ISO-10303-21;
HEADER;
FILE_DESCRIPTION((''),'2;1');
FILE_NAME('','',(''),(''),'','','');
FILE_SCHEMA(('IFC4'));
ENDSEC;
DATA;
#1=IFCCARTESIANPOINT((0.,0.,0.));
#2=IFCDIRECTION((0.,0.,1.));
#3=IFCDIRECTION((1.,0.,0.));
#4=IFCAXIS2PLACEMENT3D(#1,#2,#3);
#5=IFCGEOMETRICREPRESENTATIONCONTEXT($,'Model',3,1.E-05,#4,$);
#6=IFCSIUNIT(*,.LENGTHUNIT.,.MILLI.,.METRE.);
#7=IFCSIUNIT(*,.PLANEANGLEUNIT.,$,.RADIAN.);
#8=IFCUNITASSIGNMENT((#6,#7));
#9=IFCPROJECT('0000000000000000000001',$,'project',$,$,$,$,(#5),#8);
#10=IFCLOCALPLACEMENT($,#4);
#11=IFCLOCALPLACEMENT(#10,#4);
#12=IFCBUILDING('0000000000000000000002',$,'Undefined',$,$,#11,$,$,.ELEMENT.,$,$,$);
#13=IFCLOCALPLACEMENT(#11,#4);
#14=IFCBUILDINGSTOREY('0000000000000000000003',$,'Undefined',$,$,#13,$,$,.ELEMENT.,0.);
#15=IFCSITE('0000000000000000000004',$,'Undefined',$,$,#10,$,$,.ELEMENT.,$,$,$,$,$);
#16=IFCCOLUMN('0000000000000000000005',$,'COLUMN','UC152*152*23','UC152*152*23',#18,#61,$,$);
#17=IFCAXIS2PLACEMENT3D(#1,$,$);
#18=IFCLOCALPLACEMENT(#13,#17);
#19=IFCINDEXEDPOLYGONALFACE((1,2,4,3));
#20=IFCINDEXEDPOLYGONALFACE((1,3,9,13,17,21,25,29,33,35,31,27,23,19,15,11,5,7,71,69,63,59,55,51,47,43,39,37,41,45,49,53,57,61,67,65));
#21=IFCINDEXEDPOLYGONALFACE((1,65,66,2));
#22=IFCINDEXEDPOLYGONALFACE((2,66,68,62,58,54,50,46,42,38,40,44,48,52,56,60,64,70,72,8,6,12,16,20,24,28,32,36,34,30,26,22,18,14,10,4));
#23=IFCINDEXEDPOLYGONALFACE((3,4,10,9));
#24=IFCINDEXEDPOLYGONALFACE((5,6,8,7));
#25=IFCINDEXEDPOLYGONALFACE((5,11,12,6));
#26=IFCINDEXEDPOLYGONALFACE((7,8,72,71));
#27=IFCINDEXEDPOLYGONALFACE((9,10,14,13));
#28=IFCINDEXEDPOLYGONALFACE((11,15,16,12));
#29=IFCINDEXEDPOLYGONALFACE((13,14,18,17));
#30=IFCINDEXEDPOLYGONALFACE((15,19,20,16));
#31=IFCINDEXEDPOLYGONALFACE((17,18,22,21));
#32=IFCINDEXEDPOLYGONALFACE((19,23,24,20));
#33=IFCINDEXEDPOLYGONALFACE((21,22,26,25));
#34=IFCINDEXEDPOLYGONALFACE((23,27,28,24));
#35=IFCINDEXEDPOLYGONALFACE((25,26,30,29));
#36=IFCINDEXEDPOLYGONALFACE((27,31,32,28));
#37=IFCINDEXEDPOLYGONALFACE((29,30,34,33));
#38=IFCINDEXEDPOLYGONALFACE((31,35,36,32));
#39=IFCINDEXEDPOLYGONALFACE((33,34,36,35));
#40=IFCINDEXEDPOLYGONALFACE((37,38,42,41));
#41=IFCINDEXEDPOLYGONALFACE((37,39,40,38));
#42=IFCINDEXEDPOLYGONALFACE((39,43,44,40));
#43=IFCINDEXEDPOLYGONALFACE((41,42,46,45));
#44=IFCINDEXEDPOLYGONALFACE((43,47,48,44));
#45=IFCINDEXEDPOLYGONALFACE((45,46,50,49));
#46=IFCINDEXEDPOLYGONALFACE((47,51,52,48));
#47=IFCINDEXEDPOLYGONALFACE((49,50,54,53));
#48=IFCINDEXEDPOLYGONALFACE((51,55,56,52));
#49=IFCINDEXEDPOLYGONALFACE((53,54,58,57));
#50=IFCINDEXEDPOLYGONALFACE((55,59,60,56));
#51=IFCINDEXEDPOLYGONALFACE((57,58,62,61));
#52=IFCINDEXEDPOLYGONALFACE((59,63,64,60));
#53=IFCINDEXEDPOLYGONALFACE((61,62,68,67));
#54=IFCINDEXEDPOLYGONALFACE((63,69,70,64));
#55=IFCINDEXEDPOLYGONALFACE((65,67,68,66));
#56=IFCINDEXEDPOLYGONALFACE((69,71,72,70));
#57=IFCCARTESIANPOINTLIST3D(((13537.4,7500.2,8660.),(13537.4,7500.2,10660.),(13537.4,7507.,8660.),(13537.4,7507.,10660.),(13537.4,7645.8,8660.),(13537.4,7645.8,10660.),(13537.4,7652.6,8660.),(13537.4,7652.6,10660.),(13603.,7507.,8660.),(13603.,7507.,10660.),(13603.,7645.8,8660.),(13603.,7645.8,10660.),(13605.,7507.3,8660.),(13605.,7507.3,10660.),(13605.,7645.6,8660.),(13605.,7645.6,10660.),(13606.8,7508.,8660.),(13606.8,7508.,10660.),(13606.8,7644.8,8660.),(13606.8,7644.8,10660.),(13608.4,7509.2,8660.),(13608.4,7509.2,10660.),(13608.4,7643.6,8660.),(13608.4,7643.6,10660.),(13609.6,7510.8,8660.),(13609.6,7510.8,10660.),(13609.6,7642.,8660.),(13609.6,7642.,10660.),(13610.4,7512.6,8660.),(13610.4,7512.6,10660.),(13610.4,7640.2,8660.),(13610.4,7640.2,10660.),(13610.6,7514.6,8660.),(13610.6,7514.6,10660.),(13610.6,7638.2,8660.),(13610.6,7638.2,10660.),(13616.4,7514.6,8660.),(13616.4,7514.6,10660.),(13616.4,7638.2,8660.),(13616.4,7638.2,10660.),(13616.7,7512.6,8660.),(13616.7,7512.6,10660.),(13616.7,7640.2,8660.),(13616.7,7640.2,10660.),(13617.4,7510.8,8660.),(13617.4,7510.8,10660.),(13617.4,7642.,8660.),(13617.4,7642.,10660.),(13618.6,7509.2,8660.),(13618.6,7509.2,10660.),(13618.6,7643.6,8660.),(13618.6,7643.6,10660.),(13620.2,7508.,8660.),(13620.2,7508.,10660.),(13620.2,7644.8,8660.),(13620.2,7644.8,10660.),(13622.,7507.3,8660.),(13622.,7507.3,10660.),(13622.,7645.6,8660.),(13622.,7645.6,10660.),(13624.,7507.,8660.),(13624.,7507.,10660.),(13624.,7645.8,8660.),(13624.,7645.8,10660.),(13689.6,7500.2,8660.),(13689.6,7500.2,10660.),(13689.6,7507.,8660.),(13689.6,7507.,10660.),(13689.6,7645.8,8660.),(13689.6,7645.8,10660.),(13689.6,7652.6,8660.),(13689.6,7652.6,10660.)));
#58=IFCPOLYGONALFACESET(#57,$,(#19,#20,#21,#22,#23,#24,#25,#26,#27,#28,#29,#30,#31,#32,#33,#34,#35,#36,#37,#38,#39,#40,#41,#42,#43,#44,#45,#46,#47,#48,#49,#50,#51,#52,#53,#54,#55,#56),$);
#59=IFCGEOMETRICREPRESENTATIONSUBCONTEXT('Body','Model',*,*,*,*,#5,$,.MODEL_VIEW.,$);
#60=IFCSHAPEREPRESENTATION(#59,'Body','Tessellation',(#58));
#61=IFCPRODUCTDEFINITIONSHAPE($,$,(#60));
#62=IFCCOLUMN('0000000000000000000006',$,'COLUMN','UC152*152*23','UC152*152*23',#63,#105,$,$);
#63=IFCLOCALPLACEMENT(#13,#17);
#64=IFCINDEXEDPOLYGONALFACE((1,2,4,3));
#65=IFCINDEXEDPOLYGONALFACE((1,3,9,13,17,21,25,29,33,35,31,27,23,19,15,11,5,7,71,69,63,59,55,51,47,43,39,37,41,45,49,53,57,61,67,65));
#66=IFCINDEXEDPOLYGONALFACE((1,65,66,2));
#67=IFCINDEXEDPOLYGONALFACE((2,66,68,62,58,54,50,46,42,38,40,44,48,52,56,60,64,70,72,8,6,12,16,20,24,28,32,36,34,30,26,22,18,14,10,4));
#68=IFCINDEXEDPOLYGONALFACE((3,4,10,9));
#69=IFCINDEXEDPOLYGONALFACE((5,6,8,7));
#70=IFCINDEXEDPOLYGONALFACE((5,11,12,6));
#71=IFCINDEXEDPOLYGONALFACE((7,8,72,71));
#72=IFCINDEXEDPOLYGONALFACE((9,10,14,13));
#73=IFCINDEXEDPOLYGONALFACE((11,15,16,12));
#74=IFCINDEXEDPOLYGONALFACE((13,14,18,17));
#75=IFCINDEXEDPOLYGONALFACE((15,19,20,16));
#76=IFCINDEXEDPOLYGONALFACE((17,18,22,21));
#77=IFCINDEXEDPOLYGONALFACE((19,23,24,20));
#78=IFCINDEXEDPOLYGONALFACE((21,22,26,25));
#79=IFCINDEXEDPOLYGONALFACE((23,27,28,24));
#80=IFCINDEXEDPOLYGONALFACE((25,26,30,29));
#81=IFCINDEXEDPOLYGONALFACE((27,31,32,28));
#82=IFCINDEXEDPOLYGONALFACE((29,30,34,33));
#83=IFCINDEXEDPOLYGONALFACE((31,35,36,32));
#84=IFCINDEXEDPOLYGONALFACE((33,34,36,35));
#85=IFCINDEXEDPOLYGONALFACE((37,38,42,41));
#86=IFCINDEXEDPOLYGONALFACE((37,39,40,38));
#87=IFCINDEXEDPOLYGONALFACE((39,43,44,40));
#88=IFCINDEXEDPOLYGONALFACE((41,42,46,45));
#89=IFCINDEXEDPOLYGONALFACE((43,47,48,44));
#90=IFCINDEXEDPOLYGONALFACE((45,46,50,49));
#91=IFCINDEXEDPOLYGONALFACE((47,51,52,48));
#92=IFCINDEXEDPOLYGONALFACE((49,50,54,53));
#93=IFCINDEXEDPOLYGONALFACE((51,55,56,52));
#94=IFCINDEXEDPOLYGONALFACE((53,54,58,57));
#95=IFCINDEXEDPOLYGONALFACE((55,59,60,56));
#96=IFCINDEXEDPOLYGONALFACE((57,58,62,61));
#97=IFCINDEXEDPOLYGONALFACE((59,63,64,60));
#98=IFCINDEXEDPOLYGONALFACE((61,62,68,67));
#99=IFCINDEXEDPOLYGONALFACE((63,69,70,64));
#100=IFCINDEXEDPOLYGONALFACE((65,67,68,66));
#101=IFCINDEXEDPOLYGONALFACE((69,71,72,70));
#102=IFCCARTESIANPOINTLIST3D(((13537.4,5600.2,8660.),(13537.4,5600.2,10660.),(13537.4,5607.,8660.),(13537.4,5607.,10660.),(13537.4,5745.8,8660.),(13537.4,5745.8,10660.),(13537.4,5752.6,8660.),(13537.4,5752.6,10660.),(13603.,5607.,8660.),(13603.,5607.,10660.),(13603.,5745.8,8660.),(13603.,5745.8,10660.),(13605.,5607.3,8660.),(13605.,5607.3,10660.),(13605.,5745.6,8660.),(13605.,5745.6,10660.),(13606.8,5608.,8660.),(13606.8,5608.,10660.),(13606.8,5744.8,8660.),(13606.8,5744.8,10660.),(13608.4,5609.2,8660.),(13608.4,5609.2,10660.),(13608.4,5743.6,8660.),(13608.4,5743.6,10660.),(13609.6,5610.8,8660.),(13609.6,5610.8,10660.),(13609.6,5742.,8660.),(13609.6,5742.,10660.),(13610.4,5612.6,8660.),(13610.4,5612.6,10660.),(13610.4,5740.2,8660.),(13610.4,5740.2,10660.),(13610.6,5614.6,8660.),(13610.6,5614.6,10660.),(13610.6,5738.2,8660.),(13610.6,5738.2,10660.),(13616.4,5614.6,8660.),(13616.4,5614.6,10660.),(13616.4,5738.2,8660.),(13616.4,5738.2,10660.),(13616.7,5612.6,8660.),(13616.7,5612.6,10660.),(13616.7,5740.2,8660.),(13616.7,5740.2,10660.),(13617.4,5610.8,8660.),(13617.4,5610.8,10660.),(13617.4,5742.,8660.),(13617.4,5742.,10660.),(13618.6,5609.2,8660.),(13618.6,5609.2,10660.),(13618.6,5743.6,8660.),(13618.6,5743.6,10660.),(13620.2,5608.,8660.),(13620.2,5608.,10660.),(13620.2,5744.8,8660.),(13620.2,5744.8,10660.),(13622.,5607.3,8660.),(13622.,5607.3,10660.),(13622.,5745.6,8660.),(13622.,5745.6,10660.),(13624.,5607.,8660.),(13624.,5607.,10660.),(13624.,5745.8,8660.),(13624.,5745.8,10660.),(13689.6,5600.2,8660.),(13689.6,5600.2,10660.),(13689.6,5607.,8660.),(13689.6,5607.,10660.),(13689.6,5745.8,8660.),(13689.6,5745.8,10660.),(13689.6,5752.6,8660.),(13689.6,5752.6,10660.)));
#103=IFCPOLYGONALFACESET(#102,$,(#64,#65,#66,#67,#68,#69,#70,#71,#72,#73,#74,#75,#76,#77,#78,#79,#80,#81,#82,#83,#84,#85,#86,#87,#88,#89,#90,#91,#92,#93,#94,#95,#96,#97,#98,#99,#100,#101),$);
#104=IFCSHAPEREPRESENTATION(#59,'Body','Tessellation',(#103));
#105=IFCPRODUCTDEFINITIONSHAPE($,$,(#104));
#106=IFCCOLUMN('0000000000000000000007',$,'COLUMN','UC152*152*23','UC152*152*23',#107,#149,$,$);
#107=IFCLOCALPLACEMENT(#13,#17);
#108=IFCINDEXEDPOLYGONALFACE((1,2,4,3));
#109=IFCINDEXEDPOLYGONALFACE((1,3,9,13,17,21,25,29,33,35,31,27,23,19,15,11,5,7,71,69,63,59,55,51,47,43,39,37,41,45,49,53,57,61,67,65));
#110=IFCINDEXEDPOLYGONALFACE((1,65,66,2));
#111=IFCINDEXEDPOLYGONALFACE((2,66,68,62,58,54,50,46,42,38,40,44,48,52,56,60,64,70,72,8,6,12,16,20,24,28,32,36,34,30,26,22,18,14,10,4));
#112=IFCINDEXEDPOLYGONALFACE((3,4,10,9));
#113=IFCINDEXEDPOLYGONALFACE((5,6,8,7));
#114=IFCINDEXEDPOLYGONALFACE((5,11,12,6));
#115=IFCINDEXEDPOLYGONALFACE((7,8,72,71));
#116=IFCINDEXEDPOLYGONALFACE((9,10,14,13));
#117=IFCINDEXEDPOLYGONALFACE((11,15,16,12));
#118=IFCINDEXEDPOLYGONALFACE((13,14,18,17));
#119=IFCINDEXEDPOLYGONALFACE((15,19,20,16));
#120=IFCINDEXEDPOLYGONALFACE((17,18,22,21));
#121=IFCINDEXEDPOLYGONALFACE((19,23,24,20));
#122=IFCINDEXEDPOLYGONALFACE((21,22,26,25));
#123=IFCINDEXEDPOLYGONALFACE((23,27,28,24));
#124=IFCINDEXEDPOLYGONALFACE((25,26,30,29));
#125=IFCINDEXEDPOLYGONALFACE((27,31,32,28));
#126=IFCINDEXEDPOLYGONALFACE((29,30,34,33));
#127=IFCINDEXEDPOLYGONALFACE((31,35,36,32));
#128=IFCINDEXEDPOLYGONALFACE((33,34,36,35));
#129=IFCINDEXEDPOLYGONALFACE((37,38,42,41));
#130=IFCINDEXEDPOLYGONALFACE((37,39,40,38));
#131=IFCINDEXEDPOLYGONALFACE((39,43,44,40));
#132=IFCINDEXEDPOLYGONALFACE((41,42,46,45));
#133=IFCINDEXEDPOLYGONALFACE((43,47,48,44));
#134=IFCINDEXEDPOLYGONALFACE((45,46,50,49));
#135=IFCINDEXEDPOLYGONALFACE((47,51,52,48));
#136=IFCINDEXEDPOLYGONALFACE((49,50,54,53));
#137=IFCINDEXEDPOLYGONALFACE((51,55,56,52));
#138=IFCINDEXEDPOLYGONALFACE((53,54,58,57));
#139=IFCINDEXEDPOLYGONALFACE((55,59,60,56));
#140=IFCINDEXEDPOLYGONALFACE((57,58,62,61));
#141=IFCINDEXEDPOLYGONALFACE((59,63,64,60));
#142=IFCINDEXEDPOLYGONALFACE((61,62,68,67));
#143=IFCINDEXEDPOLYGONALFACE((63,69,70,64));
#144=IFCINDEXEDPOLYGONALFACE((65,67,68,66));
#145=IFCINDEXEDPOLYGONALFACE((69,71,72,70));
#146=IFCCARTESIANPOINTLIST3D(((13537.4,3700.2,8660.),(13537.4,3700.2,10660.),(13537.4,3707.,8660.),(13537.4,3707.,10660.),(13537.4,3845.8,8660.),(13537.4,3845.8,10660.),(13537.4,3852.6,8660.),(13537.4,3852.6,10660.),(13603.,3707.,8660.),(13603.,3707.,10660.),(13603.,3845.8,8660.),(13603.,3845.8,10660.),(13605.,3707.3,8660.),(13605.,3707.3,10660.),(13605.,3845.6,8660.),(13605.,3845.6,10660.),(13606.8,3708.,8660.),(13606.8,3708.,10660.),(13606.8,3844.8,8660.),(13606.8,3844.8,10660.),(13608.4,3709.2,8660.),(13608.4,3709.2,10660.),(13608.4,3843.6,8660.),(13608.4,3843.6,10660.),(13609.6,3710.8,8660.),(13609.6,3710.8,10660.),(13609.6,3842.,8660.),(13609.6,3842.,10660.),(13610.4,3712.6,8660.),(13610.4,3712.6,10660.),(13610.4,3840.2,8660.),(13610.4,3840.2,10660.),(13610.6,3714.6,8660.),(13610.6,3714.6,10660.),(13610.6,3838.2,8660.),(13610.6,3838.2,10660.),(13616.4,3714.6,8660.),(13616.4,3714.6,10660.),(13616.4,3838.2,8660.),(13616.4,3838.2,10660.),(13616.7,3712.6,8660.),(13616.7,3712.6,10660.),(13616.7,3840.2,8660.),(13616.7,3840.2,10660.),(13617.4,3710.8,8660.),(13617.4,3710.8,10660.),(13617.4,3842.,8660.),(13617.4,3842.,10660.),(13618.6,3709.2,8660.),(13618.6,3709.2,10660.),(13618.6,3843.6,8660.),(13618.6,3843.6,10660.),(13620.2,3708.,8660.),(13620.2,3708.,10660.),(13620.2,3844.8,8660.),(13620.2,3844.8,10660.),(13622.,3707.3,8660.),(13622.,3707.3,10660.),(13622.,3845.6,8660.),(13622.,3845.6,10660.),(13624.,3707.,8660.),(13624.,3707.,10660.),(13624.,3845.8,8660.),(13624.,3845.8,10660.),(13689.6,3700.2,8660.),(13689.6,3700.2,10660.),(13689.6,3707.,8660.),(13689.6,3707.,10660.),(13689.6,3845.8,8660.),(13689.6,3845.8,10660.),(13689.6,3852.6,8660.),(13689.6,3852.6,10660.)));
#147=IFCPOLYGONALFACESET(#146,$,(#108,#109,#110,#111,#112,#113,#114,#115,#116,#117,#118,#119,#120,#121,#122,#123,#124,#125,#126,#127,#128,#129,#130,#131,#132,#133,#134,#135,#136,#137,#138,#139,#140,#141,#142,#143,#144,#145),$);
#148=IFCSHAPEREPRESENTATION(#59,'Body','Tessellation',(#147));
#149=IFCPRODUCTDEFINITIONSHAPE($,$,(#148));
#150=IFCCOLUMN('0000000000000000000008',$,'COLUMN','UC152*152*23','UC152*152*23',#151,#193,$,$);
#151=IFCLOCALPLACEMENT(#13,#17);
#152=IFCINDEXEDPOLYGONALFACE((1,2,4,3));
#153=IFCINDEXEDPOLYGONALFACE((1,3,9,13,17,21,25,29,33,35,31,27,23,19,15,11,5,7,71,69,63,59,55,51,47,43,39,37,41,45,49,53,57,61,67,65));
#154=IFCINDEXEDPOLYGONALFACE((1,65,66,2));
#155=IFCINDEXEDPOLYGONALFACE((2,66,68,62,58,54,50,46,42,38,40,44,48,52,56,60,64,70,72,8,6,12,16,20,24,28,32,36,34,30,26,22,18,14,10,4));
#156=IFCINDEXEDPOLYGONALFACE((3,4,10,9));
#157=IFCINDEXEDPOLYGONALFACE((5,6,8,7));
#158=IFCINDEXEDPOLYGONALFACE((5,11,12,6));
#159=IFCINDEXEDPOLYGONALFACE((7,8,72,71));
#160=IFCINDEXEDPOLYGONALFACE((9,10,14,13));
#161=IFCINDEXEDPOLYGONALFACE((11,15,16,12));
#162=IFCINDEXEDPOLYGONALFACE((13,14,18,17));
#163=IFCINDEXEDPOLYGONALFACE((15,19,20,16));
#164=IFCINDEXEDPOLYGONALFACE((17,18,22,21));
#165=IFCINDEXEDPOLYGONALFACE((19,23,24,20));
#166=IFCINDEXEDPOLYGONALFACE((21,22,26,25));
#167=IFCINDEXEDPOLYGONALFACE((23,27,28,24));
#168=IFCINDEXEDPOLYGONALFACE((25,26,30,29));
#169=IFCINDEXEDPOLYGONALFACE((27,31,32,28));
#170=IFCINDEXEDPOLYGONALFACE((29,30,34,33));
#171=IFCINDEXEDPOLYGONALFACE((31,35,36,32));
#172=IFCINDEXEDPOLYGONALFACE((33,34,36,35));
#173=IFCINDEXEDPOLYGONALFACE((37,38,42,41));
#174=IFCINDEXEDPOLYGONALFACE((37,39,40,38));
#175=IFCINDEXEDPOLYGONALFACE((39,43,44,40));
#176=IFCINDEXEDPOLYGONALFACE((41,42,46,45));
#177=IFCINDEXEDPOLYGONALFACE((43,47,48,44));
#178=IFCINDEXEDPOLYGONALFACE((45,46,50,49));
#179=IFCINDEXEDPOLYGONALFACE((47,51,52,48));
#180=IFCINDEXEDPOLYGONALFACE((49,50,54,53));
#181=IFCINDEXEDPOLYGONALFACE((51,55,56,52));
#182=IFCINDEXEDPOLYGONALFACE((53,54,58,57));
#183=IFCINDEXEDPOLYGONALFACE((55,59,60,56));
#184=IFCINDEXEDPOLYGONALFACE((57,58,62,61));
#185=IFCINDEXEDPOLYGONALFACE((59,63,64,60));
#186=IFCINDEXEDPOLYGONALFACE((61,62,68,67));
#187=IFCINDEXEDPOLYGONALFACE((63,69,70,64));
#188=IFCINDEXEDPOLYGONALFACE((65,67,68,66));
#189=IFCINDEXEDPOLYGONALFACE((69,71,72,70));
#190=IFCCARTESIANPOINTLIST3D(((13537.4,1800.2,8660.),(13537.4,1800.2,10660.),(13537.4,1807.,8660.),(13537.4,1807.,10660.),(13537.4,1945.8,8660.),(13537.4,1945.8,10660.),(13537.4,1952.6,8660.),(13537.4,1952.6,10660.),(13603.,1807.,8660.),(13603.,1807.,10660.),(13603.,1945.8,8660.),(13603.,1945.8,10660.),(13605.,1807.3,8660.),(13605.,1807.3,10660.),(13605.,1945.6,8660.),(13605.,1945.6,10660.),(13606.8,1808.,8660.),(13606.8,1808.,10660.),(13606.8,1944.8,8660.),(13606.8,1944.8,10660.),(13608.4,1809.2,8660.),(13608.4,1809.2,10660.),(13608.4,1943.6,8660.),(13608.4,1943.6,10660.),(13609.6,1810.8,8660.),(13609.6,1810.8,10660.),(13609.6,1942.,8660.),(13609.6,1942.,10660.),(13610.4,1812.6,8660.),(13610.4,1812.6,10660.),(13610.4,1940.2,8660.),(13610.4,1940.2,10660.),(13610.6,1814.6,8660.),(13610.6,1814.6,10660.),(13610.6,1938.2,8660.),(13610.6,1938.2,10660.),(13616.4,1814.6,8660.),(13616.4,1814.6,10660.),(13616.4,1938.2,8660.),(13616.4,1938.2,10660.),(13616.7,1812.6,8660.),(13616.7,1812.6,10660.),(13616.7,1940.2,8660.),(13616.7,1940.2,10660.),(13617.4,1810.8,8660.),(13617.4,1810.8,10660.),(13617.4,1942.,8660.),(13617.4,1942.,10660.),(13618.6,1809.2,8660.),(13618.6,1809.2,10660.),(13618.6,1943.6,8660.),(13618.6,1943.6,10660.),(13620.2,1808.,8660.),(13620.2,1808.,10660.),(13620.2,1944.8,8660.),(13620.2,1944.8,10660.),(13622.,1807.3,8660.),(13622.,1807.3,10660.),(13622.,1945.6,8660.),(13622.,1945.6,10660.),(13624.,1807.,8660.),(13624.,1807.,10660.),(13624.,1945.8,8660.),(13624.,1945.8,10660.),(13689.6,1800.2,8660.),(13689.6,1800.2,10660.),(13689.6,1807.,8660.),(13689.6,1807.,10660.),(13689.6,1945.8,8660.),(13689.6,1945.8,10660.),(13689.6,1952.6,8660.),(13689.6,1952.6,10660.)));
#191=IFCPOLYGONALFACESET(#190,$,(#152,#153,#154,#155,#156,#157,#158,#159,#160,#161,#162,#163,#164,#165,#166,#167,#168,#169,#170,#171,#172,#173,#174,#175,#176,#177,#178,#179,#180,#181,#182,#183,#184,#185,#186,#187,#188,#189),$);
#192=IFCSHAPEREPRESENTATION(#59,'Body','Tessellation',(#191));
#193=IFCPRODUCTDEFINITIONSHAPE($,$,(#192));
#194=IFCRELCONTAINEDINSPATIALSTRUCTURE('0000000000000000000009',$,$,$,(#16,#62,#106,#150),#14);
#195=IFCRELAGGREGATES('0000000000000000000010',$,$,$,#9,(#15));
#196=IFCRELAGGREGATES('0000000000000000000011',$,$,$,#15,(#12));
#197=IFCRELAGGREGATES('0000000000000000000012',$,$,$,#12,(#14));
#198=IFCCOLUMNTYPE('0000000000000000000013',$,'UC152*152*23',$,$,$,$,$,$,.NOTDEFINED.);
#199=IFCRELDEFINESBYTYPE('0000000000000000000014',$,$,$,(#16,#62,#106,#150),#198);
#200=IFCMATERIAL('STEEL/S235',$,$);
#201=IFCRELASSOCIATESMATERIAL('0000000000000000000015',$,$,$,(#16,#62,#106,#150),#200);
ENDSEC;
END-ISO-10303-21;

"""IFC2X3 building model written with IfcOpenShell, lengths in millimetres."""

from ifc_helpers import new_model, si_unit, frame, origin_with_axes, origin_2d_with_axis, place, context, subcontext, project, spatial, i_section, extrude, material, type_object, element, save


model = new_model("IFC2X3")

# Units and contexts
model_context = context("Model", 3, precision=1e-05, world=origin_with_axes())
body_context = subcontext(model_context, "Body", "Model", "MODEL_VIEW")
ifc_project = project(units=[si_unit("LENGTHUNIT", "METRE", prefix="MILLI"), si_unit("PLANEANGLEUNIT", "RADIAN")], contexts=[model_context])

# Site, building, storey
site_placement = place(None, origin_with_axes())
site = spatial("IfcSite", under=ifc_project, at=site_placement, Name="Undefined", CompositionType="ELEMENT")
building_placement = place(site_placement, origin_with_axes())
building = spatial("IfcBuilding", under=site, at=building_placement, Name="Undefined", CompositionType="ELEMENT")
storey_placement = place(building_placement, origin_with_axes())
storey = spatial("IfcBuildingStorey", under=building, at=storey_placement, Name="Undefined", CompositionType="ELEMENT", Elevation=0.0)

# Columns
ifc_material = material(Name="STEEL/S235")
column_type = type_object("IfcColumnType", Name="UC152*152*23", PredefinedType="NOTDEFINED")
for number, where, z_axis, x_axis, name in (
    (1, (13613.5, 7576.4, 8660.0), (0.0, 0.0, 1.0), (0.0, -1.0, 0.0), "COLUMN"),
    (2, (13613.5, 5676.4, 8660.0), (0.0, 0.0, 1.0), (0.0, -1.0, 0.0), "COLUMN"),
    (3, (13613.5, 3776.4, 8660.0), (0.0, 0.0, 1.0), (0.0, -1.0, 0.0), "COLUMN"),
    (4, (13613.5, 1876.4, 8660.0), (0.0, 0.0, 1.0), (0.0, -1.0, 0.0), "COLUMN"),
):
    element("IfcColumn", number, at=place(storey_placement, frame(where, z_axis=z_axis, x_axis=x_axis)), inside=storey, type_object=column_type, material=ifc_material, Name=name, Description="UC152*152*23", ObjectType="UC152*152*23", context=body_context, shape_type="SweptSolid", body=[
        extrude(i_section(OverallWidth=152.2, OverallDepth=152.4, WebThickness=5.8, FlangeThickness=6.8, FilletRadius=7.6, at=origin_2d_with_axis()), frame((0.0, 0.0, 2000.0), z_axis=(0.0, 0.0, -1.0), x_axis=(0.0, 1.0, 0.0)), (0.0, 0.0, 1.0), 2000.0),
    ])

save(model, "model.ifc")
